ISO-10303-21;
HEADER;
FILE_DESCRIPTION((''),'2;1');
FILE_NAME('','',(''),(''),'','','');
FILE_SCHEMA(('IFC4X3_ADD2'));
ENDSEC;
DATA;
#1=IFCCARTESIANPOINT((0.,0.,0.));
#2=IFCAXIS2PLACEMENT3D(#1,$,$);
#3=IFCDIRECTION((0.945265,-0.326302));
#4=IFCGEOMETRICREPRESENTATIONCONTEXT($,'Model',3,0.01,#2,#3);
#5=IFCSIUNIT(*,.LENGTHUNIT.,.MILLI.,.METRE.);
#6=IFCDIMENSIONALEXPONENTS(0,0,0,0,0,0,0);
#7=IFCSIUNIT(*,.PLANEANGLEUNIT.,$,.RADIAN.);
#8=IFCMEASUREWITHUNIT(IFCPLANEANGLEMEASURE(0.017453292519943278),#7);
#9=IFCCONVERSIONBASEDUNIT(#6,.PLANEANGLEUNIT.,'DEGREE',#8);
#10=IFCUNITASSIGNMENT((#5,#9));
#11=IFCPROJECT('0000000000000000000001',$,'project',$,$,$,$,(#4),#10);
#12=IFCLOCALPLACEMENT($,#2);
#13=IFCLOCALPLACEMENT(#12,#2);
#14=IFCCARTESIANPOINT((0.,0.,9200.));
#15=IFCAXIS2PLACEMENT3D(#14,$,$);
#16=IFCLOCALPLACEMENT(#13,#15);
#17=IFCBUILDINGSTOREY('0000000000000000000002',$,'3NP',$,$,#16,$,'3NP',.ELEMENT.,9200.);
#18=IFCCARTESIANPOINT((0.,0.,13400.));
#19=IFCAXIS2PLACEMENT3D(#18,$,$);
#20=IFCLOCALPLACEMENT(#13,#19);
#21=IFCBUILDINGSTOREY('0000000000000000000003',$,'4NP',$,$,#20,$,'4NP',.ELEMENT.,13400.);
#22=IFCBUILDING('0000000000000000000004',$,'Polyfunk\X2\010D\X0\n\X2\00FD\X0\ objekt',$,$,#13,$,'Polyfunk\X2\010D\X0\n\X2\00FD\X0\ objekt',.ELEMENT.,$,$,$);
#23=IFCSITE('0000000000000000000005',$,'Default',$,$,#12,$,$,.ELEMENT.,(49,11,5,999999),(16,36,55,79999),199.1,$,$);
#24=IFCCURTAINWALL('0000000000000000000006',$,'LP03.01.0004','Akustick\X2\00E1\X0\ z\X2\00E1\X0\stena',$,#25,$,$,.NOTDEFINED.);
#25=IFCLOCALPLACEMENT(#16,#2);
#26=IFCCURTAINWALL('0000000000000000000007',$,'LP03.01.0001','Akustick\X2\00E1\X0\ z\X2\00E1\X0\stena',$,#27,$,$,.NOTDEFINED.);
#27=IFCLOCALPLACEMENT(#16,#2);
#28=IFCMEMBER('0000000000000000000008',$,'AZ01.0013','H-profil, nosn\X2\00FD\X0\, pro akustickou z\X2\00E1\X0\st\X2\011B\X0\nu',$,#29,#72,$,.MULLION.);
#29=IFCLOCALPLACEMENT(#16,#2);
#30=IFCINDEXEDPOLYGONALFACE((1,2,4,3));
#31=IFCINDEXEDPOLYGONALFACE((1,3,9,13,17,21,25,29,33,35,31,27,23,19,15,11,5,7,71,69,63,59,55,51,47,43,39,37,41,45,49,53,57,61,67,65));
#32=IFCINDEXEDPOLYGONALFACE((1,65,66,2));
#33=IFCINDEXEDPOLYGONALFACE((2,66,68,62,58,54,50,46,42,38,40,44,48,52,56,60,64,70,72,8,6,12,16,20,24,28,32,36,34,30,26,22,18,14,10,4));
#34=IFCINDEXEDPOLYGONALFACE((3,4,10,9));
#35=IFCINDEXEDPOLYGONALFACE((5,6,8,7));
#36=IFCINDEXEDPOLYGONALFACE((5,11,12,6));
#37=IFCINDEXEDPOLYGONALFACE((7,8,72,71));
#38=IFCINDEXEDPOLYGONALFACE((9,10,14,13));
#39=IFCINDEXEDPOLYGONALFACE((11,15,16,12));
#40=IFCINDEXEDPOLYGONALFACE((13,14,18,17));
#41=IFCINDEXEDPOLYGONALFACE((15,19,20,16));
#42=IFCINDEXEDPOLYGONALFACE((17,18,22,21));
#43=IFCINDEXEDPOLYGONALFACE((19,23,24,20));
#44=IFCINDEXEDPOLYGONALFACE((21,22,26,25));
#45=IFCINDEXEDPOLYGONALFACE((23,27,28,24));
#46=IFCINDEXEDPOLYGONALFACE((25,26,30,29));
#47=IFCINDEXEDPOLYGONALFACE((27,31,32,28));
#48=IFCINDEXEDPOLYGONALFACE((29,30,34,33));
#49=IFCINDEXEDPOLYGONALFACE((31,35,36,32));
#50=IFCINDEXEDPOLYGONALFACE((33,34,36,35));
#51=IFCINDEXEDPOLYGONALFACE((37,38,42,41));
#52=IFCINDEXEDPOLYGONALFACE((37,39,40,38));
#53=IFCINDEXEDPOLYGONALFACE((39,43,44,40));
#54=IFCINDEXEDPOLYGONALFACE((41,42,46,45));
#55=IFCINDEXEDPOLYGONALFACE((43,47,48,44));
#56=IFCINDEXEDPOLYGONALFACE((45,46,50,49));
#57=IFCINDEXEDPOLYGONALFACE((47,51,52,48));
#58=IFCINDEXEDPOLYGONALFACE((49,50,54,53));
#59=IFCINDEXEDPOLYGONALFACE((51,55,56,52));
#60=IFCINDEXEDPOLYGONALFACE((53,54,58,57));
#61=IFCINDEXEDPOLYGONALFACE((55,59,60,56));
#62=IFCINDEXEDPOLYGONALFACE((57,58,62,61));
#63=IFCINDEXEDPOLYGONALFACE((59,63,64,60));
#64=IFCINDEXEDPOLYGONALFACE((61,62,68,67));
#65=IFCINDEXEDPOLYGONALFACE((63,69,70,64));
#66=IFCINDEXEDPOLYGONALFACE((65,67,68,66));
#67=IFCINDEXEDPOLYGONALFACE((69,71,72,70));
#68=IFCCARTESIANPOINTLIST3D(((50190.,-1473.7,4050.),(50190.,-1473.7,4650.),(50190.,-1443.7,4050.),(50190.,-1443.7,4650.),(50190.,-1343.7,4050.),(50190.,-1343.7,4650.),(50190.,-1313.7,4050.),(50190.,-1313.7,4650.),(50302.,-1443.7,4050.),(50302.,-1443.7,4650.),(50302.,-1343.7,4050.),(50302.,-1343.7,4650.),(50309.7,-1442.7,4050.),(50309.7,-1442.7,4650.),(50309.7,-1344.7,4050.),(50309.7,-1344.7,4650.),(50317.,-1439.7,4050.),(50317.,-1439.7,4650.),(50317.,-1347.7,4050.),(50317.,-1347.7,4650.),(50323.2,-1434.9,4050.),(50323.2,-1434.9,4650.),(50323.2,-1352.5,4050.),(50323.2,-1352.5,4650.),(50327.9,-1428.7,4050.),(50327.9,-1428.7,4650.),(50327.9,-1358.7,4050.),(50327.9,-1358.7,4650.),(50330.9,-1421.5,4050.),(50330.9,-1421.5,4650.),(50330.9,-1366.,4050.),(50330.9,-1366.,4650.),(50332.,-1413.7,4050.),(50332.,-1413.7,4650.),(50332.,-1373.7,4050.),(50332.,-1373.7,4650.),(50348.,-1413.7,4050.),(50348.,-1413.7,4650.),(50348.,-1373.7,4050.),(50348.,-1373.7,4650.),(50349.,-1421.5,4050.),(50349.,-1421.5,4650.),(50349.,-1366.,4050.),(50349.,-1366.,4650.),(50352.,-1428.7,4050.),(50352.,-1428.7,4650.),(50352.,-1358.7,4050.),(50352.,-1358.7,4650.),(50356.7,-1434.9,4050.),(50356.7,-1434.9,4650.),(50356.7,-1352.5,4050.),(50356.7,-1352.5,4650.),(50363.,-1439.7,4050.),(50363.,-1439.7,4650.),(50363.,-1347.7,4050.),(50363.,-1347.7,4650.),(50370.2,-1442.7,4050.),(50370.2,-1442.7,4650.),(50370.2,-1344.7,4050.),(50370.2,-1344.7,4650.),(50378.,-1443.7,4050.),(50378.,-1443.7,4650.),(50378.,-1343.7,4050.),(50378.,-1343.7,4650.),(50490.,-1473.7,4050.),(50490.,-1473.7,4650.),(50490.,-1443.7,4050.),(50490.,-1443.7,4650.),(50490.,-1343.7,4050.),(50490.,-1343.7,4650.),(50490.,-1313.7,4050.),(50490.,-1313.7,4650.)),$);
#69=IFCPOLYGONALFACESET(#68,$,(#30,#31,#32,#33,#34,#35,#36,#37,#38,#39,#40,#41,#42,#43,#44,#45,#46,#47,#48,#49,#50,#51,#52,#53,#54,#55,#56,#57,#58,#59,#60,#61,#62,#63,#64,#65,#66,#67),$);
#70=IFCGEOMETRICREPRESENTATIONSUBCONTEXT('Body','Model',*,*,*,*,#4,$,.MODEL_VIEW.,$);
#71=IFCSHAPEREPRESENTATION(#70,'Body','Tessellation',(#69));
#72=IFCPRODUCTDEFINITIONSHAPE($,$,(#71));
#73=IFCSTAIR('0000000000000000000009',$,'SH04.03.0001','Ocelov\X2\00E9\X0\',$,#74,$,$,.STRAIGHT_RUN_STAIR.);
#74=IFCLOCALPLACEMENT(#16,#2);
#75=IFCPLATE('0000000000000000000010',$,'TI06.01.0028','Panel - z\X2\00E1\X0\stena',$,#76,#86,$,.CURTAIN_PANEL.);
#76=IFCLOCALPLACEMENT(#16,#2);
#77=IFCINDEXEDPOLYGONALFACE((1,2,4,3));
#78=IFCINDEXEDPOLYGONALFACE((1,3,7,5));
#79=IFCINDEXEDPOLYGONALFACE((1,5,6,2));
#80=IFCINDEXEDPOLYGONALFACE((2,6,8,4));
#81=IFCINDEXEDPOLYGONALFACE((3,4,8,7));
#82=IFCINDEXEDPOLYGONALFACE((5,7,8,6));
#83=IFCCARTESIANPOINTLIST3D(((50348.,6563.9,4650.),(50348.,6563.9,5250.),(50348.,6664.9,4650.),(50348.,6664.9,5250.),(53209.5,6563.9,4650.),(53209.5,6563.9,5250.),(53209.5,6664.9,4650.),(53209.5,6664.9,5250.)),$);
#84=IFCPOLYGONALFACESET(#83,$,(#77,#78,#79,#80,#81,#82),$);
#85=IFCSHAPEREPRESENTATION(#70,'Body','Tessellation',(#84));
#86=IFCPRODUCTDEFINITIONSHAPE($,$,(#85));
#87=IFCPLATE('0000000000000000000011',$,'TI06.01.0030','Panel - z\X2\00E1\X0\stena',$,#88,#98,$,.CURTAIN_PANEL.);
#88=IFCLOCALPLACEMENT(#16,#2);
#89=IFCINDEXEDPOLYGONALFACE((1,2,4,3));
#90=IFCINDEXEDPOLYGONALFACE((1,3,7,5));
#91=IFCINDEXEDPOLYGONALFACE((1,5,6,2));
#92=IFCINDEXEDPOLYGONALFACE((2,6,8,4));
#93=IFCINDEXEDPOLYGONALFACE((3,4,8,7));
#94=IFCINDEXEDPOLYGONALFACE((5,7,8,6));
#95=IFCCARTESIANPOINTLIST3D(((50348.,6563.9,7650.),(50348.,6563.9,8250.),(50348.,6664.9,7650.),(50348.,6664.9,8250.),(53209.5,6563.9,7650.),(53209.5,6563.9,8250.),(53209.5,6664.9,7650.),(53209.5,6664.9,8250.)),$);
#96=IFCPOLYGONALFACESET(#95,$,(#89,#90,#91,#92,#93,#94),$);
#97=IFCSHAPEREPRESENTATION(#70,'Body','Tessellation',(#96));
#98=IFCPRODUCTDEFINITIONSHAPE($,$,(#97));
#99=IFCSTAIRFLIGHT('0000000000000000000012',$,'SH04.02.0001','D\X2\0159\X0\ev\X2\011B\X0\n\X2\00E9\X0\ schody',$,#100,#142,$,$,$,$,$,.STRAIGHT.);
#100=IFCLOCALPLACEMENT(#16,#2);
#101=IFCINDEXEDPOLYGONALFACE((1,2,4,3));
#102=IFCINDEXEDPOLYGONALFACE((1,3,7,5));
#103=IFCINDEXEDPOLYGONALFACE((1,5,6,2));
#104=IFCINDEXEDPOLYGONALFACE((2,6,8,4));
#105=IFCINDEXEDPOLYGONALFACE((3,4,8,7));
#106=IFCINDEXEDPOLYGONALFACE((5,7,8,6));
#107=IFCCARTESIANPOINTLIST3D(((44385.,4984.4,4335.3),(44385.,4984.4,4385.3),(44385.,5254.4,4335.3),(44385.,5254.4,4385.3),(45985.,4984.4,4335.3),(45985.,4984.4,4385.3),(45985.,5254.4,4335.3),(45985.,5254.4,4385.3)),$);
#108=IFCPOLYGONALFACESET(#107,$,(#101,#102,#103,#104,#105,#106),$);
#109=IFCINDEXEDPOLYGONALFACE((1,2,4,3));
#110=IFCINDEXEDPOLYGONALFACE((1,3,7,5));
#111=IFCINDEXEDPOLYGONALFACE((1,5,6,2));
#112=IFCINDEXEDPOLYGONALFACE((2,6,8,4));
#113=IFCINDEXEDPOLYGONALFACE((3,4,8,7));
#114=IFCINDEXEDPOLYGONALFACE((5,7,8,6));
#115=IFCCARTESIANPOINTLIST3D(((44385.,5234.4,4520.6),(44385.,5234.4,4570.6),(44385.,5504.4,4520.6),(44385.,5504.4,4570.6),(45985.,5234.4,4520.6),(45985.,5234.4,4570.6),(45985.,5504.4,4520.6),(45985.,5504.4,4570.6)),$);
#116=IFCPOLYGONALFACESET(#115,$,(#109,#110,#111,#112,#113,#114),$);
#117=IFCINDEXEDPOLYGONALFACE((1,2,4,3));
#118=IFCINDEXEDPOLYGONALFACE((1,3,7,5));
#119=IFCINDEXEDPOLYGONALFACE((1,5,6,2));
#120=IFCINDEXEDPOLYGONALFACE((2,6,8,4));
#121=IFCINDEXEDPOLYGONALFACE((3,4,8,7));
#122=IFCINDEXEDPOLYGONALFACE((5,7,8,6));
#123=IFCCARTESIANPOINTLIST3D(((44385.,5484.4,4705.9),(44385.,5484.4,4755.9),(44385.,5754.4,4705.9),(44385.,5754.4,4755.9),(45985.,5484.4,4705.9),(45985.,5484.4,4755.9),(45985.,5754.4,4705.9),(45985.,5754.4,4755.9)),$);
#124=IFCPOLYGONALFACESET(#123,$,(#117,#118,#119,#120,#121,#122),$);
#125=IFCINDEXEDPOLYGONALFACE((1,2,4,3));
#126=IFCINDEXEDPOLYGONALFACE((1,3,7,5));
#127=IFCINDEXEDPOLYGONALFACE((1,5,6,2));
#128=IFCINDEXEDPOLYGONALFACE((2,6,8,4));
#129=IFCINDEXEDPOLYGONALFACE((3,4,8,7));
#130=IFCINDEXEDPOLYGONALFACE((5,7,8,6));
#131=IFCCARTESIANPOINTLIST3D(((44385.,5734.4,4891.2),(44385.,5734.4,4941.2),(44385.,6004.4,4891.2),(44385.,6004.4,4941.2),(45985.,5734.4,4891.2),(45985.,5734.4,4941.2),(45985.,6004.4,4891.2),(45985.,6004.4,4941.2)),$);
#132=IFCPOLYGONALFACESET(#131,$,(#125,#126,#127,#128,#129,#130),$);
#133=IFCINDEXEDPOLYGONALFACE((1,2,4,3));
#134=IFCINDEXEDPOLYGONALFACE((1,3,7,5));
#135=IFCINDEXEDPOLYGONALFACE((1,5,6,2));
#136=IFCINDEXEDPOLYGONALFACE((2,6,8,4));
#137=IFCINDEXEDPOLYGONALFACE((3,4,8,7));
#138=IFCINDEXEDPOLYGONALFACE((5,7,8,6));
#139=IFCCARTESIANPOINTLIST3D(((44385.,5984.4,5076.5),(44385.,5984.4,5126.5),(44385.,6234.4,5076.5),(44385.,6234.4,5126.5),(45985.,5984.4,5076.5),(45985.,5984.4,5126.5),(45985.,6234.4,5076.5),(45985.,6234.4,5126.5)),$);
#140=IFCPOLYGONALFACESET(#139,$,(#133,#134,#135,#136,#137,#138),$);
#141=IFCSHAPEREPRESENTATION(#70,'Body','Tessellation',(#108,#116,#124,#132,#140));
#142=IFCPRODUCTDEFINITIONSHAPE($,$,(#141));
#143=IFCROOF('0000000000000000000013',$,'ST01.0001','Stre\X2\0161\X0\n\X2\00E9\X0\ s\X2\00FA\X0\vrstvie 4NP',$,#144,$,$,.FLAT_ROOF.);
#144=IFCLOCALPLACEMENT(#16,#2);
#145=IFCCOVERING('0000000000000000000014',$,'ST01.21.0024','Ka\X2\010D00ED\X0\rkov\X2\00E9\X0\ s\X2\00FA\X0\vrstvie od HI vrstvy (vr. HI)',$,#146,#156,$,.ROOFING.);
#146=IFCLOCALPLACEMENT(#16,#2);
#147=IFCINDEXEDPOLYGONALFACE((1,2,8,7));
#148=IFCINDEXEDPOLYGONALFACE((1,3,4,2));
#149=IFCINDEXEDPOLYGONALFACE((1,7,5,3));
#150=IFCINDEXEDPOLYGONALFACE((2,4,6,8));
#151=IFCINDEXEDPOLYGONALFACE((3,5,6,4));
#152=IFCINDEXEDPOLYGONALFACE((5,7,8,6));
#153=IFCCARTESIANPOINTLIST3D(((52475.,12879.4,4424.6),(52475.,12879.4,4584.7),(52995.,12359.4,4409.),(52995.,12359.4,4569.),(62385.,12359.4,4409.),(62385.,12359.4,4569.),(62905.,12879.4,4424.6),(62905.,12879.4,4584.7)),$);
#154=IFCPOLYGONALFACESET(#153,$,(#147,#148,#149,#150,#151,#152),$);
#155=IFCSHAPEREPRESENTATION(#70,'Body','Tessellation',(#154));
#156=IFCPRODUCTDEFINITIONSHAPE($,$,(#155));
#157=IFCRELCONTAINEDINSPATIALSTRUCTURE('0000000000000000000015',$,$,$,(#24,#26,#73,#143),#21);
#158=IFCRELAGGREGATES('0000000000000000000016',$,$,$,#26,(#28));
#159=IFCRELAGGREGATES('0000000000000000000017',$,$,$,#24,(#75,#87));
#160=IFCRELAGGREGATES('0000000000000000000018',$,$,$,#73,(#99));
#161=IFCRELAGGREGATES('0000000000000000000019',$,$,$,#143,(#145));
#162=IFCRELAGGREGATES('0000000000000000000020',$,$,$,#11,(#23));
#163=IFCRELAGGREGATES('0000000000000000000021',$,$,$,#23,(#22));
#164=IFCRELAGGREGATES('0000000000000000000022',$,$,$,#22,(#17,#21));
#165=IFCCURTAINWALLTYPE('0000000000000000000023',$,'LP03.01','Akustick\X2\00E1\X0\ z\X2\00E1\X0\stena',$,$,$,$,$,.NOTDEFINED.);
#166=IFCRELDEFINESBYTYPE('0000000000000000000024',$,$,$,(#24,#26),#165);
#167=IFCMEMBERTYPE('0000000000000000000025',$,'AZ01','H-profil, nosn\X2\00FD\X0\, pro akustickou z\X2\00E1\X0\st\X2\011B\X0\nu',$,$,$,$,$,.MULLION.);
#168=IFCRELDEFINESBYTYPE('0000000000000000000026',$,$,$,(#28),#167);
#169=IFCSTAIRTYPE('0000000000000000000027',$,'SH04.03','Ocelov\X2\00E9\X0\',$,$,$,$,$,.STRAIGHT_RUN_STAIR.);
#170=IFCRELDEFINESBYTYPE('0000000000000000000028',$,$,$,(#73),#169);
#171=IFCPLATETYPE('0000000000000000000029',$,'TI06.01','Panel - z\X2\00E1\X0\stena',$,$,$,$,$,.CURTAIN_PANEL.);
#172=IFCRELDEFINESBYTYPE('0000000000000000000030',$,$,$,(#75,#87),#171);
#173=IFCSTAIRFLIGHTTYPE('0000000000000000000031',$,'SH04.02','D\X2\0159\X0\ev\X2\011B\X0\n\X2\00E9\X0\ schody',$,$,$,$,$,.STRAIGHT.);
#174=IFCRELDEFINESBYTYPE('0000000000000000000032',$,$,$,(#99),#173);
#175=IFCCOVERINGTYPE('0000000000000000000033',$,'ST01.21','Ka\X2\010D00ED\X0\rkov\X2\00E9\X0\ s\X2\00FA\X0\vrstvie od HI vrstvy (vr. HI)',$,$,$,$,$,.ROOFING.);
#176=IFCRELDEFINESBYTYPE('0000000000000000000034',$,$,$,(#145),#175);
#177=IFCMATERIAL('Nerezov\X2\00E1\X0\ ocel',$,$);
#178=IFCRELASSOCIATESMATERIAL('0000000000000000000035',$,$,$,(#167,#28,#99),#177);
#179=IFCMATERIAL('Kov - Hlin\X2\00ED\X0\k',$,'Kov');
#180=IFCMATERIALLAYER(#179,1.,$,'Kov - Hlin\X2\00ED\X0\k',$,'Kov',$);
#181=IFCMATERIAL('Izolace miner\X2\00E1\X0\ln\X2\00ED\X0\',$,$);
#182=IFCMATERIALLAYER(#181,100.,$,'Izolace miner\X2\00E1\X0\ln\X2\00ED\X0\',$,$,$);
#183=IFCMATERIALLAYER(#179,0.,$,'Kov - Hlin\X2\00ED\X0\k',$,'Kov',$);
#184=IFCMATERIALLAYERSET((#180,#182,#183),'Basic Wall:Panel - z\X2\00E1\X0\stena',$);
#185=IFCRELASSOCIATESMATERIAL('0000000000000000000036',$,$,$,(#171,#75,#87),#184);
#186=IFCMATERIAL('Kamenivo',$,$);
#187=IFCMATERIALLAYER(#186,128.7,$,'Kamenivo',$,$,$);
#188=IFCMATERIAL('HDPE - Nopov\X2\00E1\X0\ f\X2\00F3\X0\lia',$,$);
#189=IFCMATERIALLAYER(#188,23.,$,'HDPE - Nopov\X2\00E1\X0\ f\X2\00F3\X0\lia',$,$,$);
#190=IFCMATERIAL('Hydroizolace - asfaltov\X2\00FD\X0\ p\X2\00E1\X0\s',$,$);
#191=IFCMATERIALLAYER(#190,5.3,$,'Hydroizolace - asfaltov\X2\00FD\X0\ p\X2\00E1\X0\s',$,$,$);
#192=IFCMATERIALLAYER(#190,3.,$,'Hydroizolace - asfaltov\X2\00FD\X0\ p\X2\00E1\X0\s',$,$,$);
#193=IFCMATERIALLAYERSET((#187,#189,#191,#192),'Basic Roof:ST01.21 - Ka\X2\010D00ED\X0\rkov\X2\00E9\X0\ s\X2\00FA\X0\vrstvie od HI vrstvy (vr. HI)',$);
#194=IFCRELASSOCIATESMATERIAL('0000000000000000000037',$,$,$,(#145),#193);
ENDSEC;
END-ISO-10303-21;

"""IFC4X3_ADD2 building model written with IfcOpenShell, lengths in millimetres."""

from ifc_helpers import new_model, entity, si_unit, converted_unit, direction, frame, frame_2d, origin, origin_2d_with_axis, place, context, subcontext, project, spatial, polyline, circle_curve, parameter, trimmed, segment, composite_curve, rectangle, outline, extrude, source, transform, mapped, material, layer, layer_set, layer_usage, material_profile, profile_set, profile_usage, type_object, element, aggregate, save


model = new_model("IFC4X3_ADD2")

# Units and contexts
model_context = context("Model", 3, precision=0.01, world=origin(), true_north=direction((0.945265, -0.326302)))
body_context = subcontext(model_context, "Body", "Model", "MODEL_VIEW")
ifc_project = project(units=[si_unit("LENGTHUNIT", "METRE", prefix="MILLI"), converted_unit("PLANEANGLEUNIT", "DEGREE", entity("IfcPlaneAngleMeasure", 0.017453292519943278), si_unit("PLANEANGLEUNIT", "RADIAN"), dimensions=[0, 0, 0, 0, 0, 0, 0])], contexts=[model_context])

# Site, building, storey
site_placement = place(None, origin())
site = spatial("IfcSite", under=ifc_project, at=site_placement, Name="Default", CompositionType="ELEMENT", RefLatitude=(49, 11, 5, 999999), RefLongitude=(16, 36, 55, 79999), RefElevation=199.1)
building_placement = place(site_placement, origin())
building = spatial("IfcBuilding", under=site, at=building_placement, Name="Polyfunkčný objekt", LongName="Polyfunkčný objekt", CompositionType="ELEMENT")
storey_1_placement = place(building_placement, frame((0.0, 0.0, 9200.0)))
storey_1 = spatial("IfcBuildingStorey", under=building, at=storey_1_placement, Name="3NP", LongName="3NP", CompositionType="ELEMENT", Elevation=9200.0)

# Shared definitions
storey_2_placement = place(building_placement, frame((0.0, 0.0, 13400.0)))
storey_2 = spatial("IfcBuildingStorey", under=building, at=storey_2_placement, Name="4NP", LongName="4NP", CompositionType="ELEMENT", Elevation=13400.0)

# Curtain walls
curtain_wall_type_1 = type_object("IfcCurtainWallType", Name="LP03.01", Description="Akustická zástena", PredefinedType="NOTDEFINED")
curtain_wall_1_placement = place(storey_2_placement, frame((0.0, 0.0, -13400.0)))
curtain_wall_1 = element("IfcCurtainWall", 1, at=curtain_wall_1_placement, inside=storey_2, type_object=curtain_wall_type_1, Name="LP03.01.0004", Description="Akustická zástena", PredefinedType="NOTDEFINED")
ifc_material_1 = material(Name="Nerezová ocel")
ifc_material_profile_1 = material_profile(ifc_material_1, outline(composite_curve([segment(polyline([(50.0, -150.0), (80.0, -150.0)]), True, "CONTINUOUS"), segment(polyline([(80.0, -150.0), (80.0, 150.0)]), True, "CONTINUOUS"), segment(polyline([(80.0, 150.0), (50.0, 150.0)]), True, "CONTINUOUS"), segment(polyline([(50.0, 150.0), (50.0, 38.0)]), True, "CONTINUOUS"), segment(trimmed(circle_curve(frame_2d((20.0, 38.0), x_axis=(0.0, 1.0)), 30.0), [parameter(180.0)], [parameter(270.0)], True, "PARAMETER"), False, "CONTINUOUS"), segment(polyline([(20.0, 8.0), (-20.0, 8.0)]), True, "CONTINUOUS"), segment(trimmed(circle_curve(frame_2d((-20.0, 38.0), x_axis=(0.0, 1.0)), 30.0), [parameter(90.0)], [parameter(180.0)], True, "PARAMETER"), False, "CONTINUOUS"), segment(polyline([(-50.0, 38.0), (-50.0, 150.0)]), True, "CONTINUOUS"), segment(polyline([(-50.0, 150.0), (-80.0, 150.0)]), True, "CONTINUOUS"), segment(polyline([(-80.0, 150.0), (-80.0, -150.0)]), True, "CONTINUOUS"), segment(polyline([(-80.0, -150.0), (-50.0, -150.0)]), True, "CONTINUOUS"), segment(polyline([(-50.0, -150.0), (-50.0, -38.0)]), True, "CONTINUOUS"), segment(trimmed(circle_curve(frame_2d((-20.0, -38.0), x_axis=(0.0, 1.0)), 30.0), [parameter(0.0)], [parameter(90.0)], True, "PARAMETER"), False, "CONTINUOUS"), segment(polyline([(-20.0, -8.0), (20.0, -8.0)]), True, "CONTINUOUS"), segment(trimmed(circle_curve(frame_2d((20.0, -38.0), x_axis=(0.0, 1.0)), 30.0), [parameter(270.0)], [parameter(0.0)], True, "PARAMETER"), False, "CONTINUOUS"), segment(polyline([(50.0, -38.0), (50.0, -150.0)]), True, "CONTINUOUS")], self_intersect=False)), Name="Profil zástena")
ifc_profile_set_1 = profile_set([ifc_material_profile_1], Name="Profil zástena")
ifc_profile_usage_1 = profile_usage(ifc_profile_set_1)
member_type_1 = type_object("IfcMemberType", Name="AZ01", Description="H-profil, nosný, pro akustickou zástěnu", PredefinedType="MULLION", material=ifc_profile_set_1)
curtain_wall_2_placement = place(storey_2_placement, frame((0.0, 0.0, -13400.0)))
curtain_wall_2 = element("IfcCurtainWall", 2, at=curtain_wall_2_placement, inside=storey_2, type_object=curtain_wall_type_1, Name="LP03.01.0001", Description="Akustická zástena", PredefinedType="NOTDEFINED")

# Member
shared_shape_1 = source(origin(), body_context, "Body", "SweptSolid", [
    extrude(outline(composite_curve([segment(polyline([(-150.0, -50.0), (-150.0, -80.0)]), True, "CONTINUOUS"), segment(polyline([(-150.0, -80.0), (150.0, -80.0)]), True, "CONTINUOUS"), segment(polyline([(150.0, -80.0), (150.0, -50.0)]), True, "CONTINUOUS"), segment(polyline([(150.0, -50.0), (38.0, -50.0)]), True, "CONTINUOUS"), segment(trimmed(circle_curve(frame_2d((38.0, -20.0), x_axis=(1.0, 0.0)), 30.0), [parameter(180.0)], [parameter(270.0)], True, "PARAMETER"), False, "CONTINUOUS"), segment(polyline([(8.0, -20.0), (8.0, 20.0)]), True, "CONTINUOUS"), segment(trimmed(circle_curve(frame_2d((38.0, 20.0), x_axis=(1.0, 0.0)), 30.0), [parameter(90.0)], [parameter(180.0)], True, "PARAMETER"), False, "CONTINUOUS"), segment(polyline([(38.0, 50.0), (150.0, 50.0)]), True, "CONTINUOUS"), segment(polyline([(150.0, 50.0), (150.0, 80.0)]), True, "CONTINUOUS"), segment(polyline([(150.0, 80.0), (-150.0, 80.0)]), True, "CONTINUOUS"), segment(polyline([(-150.0, 80.0), (-150.0, 50.0)]), True, "CONTINUOUS"), segment(polyline([(-150.0, 50.0), (-38.0, 50.0)]), True, "CONTINUOUS"), segment(trimmed(circle_curve(frame_2d((-38.0, 20.0), x_axis=(1.0, 0.0)), 30.0), [parameter(0.0)], [parameter(90.0)], True, "PARAMETER"), False, "CONTINUOUS"), segment(polyline([(-8.0, 20.0), (-8.0, -20.0)]), True, "CONTINUOUS"), segment(trimmed(circle_curve(frame_2d((-38.0, -20.0), x_axis=(1.0, 0.0)), 30.0), [parameter(270.0)], [parameter(0.0)], True, "PARAMETER"), False, "CONTINUOUS"), segment(polyline([(-38.0, -50.0), (-150.0, -50.0)]), True, "CONTINUOUS")], self_intersect=False)), frame((-150.0, 0.0, -600.0), z_axis=(0.0, 0.0, -1.0), x_axis=(-1.0, 0.0, 0.0)), (0.0, 0.0, -1.0), 600.0),
])
member_1_placement = place(curtain_wall_2_placement, frame((50190.0, -1393.7, 13850.0), z_axis=(0.0, 0.0, 1.0), x_axis=(-1.0, 0.0, 0.0)))
member_1 = element("IfcMember", 3, at=member_1_placement, type_object=member_type_1, material=ifc_profile_usage_1, Name="AZ01.0013", Description="H-profil, nosný, pro akustickou zástěnu", PredefinedType="MULLION", context=body_context, shape_type="MappedRepresentation", body=[
    mapped(shared_shape_1, transform((0.0, 0.0, 0.0), scale=1.0)),
])
aggregate(curtain_wall_2, [member_1])

# Stair
stair_type = type_object("IfcStairType", Name="SH04.03", Description="Ocelové", PredefinedType="STRAIGHT_RUN_STAIR")
stair_placement = place(storey_2_placement, origin())
stair = element("IfcStair", 4, at=stair_placement, inside=storey_2, type_object=stair_type, Name="SH04.03.0001", Description="Ocelové", PredefinedType="STRAIGHT_RUN_STAIR")

# Plates
ifc_material_2 = material(Name="Kov - Hliník", Category="Kov")
ifc_layer_1 = layer(ifc_material_2, 1.0, Name="Kov - Hliník", Category="Kov")
ifc_material_3 = material(Name="Izolace minerální")
ifc_layer_2 = layer(ifc_material_3, 100.0, Name="Izolace minerální")
ifc_layer_3 = layer(ifc_material_2, 0.0, Name="Kov - Hliník", Category="Kov")
ifc_layer_set_1 = layer_set([ifc_layer_1, ifc_layer_2, ifc_layer_3], Name="Basic Wall:Panel - zástena")
ifc_layer_usage_1 = layer_usage(ifc_layer_set_1, "AXIS2", "POSITIVE", -50.5)
plate_type = type_object("IfcPlateType", Name="TI06.01", Description="Panel - zástena", PredefinedType="CURTAIN_PANEL", material=ifc_layer_set_1)
plate_1_placement = place(storey_2_placement, frame((50348.0, 6614.4, 450.0)))
plate_1 = element("IfcPlate", 5, at=plate_1_placement, type_object=plate_type, material=ifc_layer_usage_1, Name="TI06.01.0028", Description="Panel - zástena", PredefinedType="CURTAIN_PANEL", context=body_context, shape_type="SweptSolid", body=[
    extrude(rectangle(XDim=101.0, YDim=2861.5, at=frame_2d((0.0, 0.0), x_axis=(1.0, 0.0))), frame((1430.7, 0.0, 0.0), z_axis=(0.0, 0.0, 1.0), x_axis=(0.0, 1.0, 0.0)), (0.0, 0.0, 1.0), 600.0),
])
ifc_layer_usage_2 = layer_usage(ifc_layer_set_1, "AXIS2", "POSITIVE", -50.5)
plate_2_placement = place(storey_2_placement, frame((50348.0, 6614.4, 3450.0)))
plate_2 = element("IfcPlate", 6, at=plate_2_placement, type_object=plate_type, material=ifc_layer_usage_2, Name="TI06.01.0030", Description="Panel - zástena", PredefinedType="CURTAIN_PANEL", context=body_context, shape_type="SweptSolid", body=[
    extrude(rectangle(XDim=101.0, YDim=2861.5, at=frame_2d((0.0, 0.0), x_axis=(1.0, 0.0))), frame((1430.7, 0.0, 0.0), z_axis=(0.0, 0.0, 1.0), x_axis=(0.0, 1.0, 0.0)), (0.0, 0.0, 1.0), 600.0),
])
aggregate(curtain_wall_1, [plate_1, plate_2])

# Stair flight
stair_flight_type = type_object("IfcStairFlightType", Name="SH04.02", Description="Dřevěné schody", PredefinedType="STRAIGHT")
stair_flight_placement = place(stair_placement, frame((44385.0, 4984.4, 0.0)))
stair_flight = element("IfcStairFlight", 7, at=stair_flight_placement, type_object=stair_flight_type, material=ifc_material_1, Name="SH04.02.0001", Description="Dřevěné schody", PredefinedType="STRAIGHT", context=body_context, shape_type="SweptSolid", body=[
    extrude(rectangle(XDim=270.0, YDim=1600.0, at=origin_2d_with_axis()), frame((800.0, 135.0, 135.3), z_axis=(0.0, 0.0, 1.0), x_axis=(0.0, -1.0, 0.0)), (0.0, 0.0, 1.0), 50.0),
    extrude(rectangle(XDim=270.0, YDim=1600.0, at=origin_2d_with_axis()), frame((800.0, 385.0, 320.6), z_axis=(0.0, 0.0, 1.0), x_axis=(0.0, -1.0, 0.0)), (0.0, 0.0, 1.0), 50.0),
    extrude(rectangle(XDim=270.0, YDim=1600.0, at=origin_2d_with_axis()), frame((800.0, 635.0, 505.9), z_axis=(0.0, 0.0, 1.0), x_axis=(0.0, -1.0, 0.0)), (0.0, 0.0, 1.0), 50.0),
    extrude(rectangle(XDim=270.0, YDim=1600.0, at=origin_2d_with_axis()), frame((800.0, 885.0, 691.2), z_axis=(0.0, 0.0, 1.0), x_axis=(0.0, -1.0, 0.0)), (0.0, 0.0, 1.0), 50.0),
    extrude(rectangle(XDim=250.0, YDim=1600.0, at=origin_2d_with_axis()), frame((800.0, 1125.0, 876.5), z_axis=(0.0, 0.0, 1.0), x_axis=(0.0, -1.0, 0.0)), (0.0, 0.0, 1.0), 50.0),
])
aggregate(stair, [stair_flight])

# Roof, covering
roof = element("IfcRoof", 8, inside=storey_2, Name="ST01.0001", Description="Strešné súvrstvie 4NP", PredefinedType="FLAT_ROOF")
ifc_material_4 = material(Name="Kamenivo")
ifc_layer_4 = layer(ifc_material_4, 128.7, Name="Kamenivo")
ifc_material_5 = material(Name="HDPE - Nopová fólia")
ifc_layer_5 = layer(ifc_material_5, 23.0, Name="HDPE - Nopová fólia")
ifc_material_6 = material(Name="Hydroizolace - asfaltový pás")
ifc_layer_6 = layer(ifc_material_6, 5.3, Name="Hydroizolace - asfaltový pás")
ifc_layer_7 = layer(ifc_material_6, 3.0, Name="Hydroizolace - asfaltový pás")
ifc_layer_set_2 = layer_set([ifc_layer_4, ifc_layer_5, ifc_layer_6, ifc_layer_7], Name="Basic Roof:ST01.21 - Kačírkové súvrstvie od HI vrstvy (vr. HI)")
covering_type = type_object("IfcCoveringType", Name="ST01.21", Description="Kačírkové súvrstvie od HI vrstvy (vr. HI)", PredefinedType="ROOFING")
placement_1 = place(storey_2_placement, frame((52475.0, 12359.4, 209.0)))
covering_1_placement = place(placement_1, origin())
covering_1 = element("IfcCovering", 9, at=covering_1_placement, type_object=covering_type, material=ifc_layer_set_2, Name="ST01.21.0024", Description="Kačírkové súvrstvie od HI vrstvy (vr. HI)", PredefinedType="ROOFING", context=body_context, shape_type="SweptSolid", body=[
    extrude(outline(polyline([(4695.0, -260.1), (5215.0, 260.1), (-5215.0, 260.1), (-4695.0, -260.1), (4695.0, -260.1)])), frame((5215.0, 260.0, 7.8), z_axis=(0.0, -0.030015, 0.999549), x_axis=(1.0, 0.0, 0.0)), (0.0, 0.030015, 0.999549), 160.1),
])
aggregate(roof, [covering_1])

save(model, "model.ifc")
